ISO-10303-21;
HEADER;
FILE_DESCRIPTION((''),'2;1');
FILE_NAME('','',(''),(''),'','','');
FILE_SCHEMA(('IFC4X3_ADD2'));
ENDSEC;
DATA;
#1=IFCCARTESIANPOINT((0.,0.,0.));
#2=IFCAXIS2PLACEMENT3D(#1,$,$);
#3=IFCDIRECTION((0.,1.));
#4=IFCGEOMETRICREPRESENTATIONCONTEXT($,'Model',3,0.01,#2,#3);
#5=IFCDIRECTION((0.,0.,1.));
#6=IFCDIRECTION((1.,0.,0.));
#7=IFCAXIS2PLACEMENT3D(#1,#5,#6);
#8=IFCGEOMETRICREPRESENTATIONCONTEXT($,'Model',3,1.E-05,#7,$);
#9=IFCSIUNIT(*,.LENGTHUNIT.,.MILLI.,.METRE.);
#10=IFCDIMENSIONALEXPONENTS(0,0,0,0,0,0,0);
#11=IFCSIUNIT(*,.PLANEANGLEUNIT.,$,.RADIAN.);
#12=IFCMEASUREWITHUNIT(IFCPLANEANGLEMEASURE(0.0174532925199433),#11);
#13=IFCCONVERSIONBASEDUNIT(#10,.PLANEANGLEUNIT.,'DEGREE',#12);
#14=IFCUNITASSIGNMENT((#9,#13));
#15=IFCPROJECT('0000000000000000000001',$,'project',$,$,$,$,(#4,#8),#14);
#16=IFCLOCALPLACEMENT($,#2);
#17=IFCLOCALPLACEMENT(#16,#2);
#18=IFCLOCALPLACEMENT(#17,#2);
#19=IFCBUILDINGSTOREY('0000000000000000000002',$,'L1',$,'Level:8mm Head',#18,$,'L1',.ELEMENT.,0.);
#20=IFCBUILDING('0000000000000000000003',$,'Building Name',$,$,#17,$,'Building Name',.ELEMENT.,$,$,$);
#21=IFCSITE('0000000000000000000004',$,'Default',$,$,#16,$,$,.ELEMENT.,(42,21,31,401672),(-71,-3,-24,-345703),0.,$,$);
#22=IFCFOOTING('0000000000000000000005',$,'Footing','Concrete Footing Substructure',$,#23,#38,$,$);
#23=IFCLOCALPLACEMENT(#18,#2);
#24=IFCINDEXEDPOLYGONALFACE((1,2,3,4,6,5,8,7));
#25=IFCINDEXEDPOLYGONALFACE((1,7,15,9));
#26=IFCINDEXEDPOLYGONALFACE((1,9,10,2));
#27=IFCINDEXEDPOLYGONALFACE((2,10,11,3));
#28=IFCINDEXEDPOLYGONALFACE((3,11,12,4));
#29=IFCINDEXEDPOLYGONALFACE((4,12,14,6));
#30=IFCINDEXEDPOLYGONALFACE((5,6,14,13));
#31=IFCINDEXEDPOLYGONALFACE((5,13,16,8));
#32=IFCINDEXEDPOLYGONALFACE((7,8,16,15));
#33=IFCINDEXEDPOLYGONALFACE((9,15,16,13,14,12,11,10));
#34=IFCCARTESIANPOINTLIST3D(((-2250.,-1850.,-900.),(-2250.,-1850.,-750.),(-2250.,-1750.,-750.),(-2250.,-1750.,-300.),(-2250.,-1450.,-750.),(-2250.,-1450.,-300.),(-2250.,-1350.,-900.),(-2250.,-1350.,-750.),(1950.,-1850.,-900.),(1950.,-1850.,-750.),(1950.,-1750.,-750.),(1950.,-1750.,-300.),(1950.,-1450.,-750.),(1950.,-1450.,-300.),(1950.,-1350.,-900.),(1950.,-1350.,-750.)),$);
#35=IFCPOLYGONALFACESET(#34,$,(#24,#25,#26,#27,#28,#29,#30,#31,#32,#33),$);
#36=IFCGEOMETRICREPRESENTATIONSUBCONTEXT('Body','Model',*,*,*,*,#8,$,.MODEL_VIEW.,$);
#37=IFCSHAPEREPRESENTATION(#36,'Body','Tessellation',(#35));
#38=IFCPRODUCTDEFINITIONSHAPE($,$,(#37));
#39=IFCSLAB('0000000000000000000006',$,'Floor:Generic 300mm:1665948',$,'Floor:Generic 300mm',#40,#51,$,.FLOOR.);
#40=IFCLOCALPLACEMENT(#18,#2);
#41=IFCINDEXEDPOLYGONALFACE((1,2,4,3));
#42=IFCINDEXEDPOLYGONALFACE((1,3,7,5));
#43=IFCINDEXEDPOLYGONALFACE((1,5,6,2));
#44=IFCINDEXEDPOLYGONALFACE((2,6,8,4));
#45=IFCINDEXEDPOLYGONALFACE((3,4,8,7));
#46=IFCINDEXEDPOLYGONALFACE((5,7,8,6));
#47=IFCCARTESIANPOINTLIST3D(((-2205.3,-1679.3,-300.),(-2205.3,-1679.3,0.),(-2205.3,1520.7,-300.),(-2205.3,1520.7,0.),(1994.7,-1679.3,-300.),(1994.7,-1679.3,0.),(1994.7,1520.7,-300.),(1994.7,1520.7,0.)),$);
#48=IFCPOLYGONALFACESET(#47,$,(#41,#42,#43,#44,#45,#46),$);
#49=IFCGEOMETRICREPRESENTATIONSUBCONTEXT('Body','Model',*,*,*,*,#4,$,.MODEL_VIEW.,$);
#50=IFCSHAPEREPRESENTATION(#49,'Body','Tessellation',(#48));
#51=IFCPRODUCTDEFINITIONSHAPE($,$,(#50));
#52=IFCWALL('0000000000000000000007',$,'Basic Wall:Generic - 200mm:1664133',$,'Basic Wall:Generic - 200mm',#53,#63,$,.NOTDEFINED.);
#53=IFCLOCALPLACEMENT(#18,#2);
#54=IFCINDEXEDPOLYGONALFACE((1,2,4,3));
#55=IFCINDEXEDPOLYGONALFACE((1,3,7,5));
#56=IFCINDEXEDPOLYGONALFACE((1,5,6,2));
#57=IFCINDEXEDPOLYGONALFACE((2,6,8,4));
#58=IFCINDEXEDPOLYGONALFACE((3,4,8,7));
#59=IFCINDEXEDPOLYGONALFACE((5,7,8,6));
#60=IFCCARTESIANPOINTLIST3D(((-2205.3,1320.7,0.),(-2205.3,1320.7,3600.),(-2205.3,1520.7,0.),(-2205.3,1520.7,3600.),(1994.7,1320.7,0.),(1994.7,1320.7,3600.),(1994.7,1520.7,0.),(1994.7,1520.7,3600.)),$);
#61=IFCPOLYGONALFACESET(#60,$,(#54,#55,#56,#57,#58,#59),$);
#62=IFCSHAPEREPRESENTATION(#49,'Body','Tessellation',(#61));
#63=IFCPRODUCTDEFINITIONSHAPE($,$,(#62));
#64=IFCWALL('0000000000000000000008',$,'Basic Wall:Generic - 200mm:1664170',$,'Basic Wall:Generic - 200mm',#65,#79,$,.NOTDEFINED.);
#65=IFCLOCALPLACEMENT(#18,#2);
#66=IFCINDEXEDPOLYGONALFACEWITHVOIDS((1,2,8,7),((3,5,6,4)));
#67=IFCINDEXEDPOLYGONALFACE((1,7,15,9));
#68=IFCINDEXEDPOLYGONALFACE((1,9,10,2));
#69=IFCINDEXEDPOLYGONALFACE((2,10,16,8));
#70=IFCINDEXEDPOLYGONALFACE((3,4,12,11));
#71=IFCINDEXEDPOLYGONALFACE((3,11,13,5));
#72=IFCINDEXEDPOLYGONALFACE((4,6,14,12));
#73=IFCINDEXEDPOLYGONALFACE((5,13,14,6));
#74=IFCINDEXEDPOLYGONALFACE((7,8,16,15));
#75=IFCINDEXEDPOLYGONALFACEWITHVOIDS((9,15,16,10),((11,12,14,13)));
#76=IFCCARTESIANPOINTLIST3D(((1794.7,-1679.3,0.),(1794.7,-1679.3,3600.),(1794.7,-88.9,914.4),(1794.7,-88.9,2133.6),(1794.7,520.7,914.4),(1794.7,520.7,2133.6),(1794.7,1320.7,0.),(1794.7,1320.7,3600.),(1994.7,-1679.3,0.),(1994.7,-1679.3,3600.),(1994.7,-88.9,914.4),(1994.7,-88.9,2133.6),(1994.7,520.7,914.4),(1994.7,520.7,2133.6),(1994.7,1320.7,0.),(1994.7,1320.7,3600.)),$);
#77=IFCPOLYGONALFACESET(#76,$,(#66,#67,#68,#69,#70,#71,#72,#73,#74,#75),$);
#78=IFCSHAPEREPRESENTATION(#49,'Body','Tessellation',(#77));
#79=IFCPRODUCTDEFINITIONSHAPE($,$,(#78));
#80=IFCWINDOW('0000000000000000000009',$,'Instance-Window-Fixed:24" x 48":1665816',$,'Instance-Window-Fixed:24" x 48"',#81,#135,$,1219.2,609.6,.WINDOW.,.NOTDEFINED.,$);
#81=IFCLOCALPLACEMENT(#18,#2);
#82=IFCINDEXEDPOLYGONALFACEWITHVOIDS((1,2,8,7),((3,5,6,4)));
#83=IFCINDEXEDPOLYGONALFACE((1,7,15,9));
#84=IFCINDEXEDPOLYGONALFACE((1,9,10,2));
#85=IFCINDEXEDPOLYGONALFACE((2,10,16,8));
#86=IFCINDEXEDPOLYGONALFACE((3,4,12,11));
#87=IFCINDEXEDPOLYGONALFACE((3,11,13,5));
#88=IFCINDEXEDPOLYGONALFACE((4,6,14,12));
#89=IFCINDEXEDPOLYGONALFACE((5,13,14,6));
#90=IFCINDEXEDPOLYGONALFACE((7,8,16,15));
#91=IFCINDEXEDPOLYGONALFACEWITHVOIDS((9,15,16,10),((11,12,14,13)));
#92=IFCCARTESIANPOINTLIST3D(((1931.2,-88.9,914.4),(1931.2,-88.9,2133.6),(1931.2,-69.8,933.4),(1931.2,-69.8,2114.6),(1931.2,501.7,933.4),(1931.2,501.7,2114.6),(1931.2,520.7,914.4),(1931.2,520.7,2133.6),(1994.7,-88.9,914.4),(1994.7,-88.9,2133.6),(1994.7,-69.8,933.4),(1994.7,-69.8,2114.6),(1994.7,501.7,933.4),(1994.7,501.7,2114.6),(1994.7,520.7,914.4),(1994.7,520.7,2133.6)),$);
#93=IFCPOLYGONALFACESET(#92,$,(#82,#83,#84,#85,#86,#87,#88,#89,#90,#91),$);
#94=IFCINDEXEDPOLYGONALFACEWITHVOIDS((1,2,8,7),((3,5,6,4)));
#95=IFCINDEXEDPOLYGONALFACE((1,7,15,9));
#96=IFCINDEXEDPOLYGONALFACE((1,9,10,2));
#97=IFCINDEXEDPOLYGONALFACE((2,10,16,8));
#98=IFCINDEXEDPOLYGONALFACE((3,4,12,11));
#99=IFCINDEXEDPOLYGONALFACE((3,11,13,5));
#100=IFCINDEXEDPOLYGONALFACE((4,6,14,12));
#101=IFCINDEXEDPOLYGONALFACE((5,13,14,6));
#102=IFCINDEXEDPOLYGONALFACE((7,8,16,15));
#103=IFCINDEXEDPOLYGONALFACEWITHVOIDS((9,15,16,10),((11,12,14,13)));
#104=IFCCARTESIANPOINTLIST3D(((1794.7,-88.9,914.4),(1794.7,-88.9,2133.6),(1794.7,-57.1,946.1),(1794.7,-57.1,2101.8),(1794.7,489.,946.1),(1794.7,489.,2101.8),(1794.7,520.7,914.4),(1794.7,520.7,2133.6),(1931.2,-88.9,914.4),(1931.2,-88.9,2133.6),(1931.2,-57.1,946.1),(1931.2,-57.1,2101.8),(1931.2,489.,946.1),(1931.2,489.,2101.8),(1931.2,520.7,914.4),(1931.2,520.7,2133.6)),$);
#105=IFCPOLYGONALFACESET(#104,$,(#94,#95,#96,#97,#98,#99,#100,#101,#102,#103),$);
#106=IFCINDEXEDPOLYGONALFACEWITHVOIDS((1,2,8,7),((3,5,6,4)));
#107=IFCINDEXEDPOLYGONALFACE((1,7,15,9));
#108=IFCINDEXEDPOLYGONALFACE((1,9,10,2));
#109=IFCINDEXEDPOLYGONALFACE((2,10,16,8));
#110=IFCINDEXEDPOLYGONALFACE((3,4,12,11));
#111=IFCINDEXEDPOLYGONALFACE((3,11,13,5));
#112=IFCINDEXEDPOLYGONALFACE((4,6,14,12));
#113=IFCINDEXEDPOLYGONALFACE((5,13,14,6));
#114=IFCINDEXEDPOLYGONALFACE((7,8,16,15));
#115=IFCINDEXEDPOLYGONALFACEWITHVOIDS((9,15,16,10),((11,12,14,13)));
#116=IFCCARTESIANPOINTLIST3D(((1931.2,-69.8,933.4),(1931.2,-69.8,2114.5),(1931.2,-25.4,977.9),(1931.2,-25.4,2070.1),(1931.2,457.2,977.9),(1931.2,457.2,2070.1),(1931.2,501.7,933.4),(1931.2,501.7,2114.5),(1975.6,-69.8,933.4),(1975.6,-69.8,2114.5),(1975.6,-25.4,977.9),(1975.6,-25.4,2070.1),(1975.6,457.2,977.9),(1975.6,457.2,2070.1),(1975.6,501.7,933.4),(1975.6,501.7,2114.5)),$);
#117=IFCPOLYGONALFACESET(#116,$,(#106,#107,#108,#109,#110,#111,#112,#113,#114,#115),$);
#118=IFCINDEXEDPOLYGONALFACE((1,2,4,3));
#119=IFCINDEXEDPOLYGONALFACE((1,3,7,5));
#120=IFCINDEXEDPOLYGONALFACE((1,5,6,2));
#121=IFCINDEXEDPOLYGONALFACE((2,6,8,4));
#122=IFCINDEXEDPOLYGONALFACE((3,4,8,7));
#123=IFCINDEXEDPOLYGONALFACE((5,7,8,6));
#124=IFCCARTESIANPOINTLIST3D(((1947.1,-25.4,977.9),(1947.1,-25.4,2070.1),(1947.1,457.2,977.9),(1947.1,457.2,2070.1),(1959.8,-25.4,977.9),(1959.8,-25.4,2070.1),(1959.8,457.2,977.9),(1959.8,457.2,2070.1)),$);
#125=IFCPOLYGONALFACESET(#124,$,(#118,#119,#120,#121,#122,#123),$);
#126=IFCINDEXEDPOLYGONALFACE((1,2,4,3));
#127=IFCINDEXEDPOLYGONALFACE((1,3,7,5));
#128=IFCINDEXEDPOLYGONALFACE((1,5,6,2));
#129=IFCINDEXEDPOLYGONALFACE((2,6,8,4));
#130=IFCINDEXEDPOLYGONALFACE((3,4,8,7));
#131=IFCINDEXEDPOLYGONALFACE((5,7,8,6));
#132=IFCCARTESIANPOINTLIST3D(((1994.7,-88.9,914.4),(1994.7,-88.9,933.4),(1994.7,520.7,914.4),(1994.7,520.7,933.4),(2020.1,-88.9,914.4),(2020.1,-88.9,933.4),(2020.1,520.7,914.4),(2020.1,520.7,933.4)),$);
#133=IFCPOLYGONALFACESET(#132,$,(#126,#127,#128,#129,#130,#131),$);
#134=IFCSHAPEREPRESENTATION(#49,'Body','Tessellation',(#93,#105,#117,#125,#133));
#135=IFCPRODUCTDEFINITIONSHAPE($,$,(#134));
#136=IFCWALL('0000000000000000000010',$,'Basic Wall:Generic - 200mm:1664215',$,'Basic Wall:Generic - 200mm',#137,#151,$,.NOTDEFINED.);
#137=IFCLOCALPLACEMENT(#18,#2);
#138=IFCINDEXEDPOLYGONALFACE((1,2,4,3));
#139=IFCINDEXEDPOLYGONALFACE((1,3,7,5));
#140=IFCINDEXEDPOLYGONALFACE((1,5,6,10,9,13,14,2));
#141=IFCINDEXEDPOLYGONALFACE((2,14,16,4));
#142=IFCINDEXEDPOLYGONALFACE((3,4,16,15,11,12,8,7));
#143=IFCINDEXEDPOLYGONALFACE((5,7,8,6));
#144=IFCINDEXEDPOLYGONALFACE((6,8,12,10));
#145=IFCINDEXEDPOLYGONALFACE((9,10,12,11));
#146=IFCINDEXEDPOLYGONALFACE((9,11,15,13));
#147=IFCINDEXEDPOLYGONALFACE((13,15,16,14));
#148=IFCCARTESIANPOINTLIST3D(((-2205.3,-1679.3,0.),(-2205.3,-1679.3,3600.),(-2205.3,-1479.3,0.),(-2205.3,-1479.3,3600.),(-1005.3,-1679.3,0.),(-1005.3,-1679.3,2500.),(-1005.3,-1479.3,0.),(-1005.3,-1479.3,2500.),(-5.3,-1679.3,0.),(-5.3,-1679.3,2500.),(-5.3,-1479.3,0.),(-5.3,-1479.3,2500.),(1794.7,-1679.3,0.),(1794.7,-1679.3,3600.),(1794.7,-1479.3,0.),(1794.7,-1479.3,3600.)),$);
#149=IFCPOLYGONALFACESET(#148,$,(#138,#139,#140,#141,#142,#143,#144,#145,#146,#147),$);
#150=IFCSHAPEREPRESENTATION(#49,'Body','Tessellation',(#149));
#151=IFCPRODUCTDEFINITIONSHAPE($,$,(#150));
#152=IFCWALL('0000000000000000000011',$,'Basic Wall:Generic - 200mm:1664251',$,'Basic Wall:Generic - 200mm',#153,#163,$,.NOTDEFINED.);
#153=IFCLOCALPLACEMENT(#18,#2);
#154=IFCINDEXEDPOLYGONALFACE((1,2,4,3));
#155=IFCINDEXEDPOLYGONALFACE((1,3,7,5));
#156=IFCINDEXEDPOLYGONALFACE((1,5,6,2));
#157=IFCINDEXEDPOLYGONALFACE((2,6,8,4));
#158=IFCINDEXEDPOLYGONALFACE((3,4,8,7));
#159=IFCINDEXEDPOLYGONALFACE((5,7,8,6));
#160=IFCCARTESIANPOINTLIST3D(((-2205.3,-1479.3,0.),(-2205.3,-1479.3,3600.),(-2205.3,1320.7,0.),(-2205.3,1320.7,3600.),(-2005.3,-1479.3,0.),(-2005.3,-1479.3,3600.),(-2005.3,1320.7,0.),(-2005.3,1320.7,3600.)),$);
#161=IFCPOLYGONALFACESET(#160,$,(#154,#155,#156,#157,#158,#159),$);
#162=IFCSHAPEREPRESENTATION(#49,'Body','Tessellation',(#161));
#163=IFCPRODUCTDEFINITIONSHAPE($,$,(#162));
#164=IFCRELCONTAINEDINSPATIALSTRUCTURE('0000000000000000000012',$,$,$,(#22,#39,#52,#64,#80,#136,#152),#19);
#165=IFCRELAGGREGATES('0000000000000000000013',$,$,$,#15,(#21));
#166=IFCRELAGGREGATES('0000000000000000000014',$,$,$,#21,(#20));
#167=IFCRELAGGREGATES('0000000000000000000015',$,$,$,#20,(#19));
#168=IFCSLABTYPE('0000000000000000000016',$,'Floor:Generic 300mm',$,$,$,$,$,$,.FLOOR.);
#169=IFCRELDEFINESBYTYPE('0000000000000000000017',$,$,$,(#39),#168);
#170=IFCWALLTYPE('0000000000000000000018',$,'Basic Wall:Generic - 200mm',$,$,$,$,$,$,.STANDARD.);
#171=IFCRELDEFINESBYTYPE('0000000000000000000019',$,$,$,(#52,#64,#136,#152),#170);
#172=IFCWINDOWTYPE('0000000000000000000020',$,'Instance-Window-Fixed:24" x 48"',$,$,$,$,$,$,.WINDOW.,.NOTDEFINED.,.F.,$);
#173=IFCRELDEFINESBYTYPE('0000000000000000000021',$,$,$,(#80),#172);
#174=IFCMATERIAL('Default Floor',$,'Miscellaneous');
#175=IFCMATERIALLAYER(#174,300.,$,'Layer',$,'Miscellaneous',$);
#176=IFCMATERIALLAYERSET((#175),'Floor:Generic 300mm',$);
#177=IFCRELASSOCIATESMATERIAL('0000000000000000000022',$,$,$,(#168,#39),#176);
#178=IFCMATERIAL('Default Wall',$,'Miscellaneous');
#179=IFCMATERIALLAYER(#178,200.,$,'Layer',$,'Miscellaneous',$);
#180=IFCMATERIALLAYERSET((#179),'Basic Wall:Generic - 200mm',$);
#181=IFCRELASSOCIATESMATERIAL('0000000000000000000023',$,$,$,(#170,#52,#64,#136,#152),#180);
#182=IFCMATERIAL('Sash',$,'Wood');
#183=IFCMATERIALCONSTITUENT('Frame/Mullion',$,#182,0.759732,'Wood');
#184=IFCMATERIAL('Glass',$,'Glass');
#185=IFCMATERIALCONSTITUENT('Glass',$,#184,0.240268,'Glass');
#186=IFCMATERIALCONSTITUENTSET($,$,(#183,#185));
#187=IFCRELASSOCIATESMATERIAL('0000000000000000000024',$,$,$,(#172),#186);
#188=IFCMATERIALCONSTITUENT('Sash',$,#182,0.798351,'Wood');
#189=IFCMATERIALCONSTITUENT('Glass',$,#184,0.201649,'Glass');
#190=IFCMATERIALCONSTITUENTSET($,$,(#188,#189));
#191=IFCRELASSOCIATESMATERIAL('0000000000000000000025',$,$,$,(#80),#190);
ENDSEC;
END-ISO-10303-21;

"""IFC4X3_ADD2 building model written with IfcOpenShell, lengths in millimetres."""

from ifc_helpers import new_model, entity, si_unit, converted_unit, direction, frame, frame_2d, origin, origin_with_axes, origin_2d_with_axis, place, context, subcontext, project, spatial, polyline, rectangle, t_section, outline, extrude, source, transform, mapped, material, layer, layer_set, layer_usage, constituent, constituent_set, type_object, type_shapes, element, fill, save


model = new_model("IFC4X3_ADD2")

# Units and contexts
model_context_1 = context("Model", 3, precision=0.01, world=origin(), true_north=direction((0.0, 1.0)))
model_context_2 = context("Model", 3, precision=1e-05, world=origin_with_axes())
body_context_1 = subcontext(model_context_1, "Body", "Model", "MODEL_VIEW")
body_context_2 = subcontext(model_context_2, "Body", "Model", "MODEL_VIEW")
ifc_project = project(units=[si_unit("LENGTHUNIT", "METRE", prefix="MILLI"), converted_unit("PLANEANGLEUNIT", "DEGREE", entity("IfcPlaneAngleMeasure", 0.0174532925199433), si_unit("PLANEANGLEUNIT", "RADIAN"), dimensions=[0, 0, 0, 0, 0, 0, 0])], contexts=[model_context_1, model_context_2])

# Site, building, storey
site_placement = place(None, origin())
site = spatial("IfcSite", under=ifc_project, at=site_placement, Name="Default", CompositionType="ELEMENT", RefLatitude=(42, 21, 31, 401672), RefLongitude=(-71, -3, -24, -345703), RefElevation=0.0)
building_placement = place(site_placement, origin())
building = spatial("IfcBuilding", under=site, at=building_placement, Name="Building Name", LongName="Building Name", CompositionType="ELEMENT")
storey_placement = place(building_placement, origin())
storey = spatial("IfcBuildingStorey", under=building, at=storey_placement, Name="L1", ObjectType="Level:8mm Head", LongName="L1", CompositionType="ELEMENT", Elevation=0.0)

# Footing
footing_placement = place(storey_placement, frame((-2250.0, -1600.0, -600.0), z_axis=(1.0, 0.0, 0.0), x_axis=(0.0, -1.0, 0.0)))
element("IfcFooting", 1, at=footing_placement, inside=storey, Name="Footing", Description="Concrete Footing Substructure", context=body_context_2, shape_type="SweptSolid", body=[
    extrude(t_section(Depth=600.0, FlangeWidth=500.0, WebThickness=300.0, FlangeThickness=150.0), origin_with_axes(), (0.0, 0.0, 1.0), 4200.0),
])

# Slab
ifc_material_1 = material(Name="Default Floor", Category="Miscellaneous")
ifc_layer_1 = layer(ifc_material_1, 300.0, Name="Layer", Category="Miscellaneous")
ifc_layer_set_1 = layer_set([ifc_layer_1], Name="Floor:Generic 300mm")
ifc_layer_usage = layer_usage(ifc_layer_set_1, "AXIS3", "POSITIVE", 0.0)
slab_type = type_object("IfcSlabType", Name="Floor:Generic 300mm", PredefinedType="FLOOR", material=ifc_layer_set_1)
slab_placement = place(storey_placement, origin())
element("IfcSlab", 2, at=slab_placement, inside=storey, type_object=slab_type, material=ifc_layer_usage, Name="Floor:Generic 300mm:1665948", ObjectType="Floor:Generic 300mm", PredefinedType="FLOOR", context=body_context_1, shape_type="SweptSolid", body=[
    extrude(rectangle(XDim=3200.0, YDim=4200.0, at=origin_2d_with_axis()), frame((-105.3, -79.3, 0.0), z_axis=(0.0, 0.0, -1.0), x_axis=(0.0, 1.0, 0.0)), (0.0, 0.0, 1.0), 300.0),
])

# Wall
ifc_material_2 = material(Name="Default Wall", Category="Miscellaneous")
ifc_layer_2 = layer(ifc_material_2, 200.0, Name="Layer", Category="Miscellaneous")
ifc_layer_set_2 = layer_set([ifc_layer_2], Name="Basic Wall:Generic - 200mm")
wall_type = type_object("IfcWallType", Name="Basic Wall:Generic - 200mm", PredefinedType="STANDARD", material=ifc_layer_set_2)
wall_1_placement = place(storey_placement, frame((-2205.3, 1420.7, 0.0)))
element("IfcWall", 3, at=wall_1_placement, inside=storey, type_object=wall_type, material=ifc_layer_set_2, Name="Basic Wall:Generic - 200mm:1664133", ObjectType="Basic Wall:Generic - 200mm", PredefinedType="NOTDEFINED", context=body_context_1, shape_type="SweptSolid", body=[
    extrude(rectangle(XDim=4200.0, YDim=200.0, at=frame_2d((2100.0, 0.0), x_axis=(-1.0, 0.0))), origin(), (0.0, 0.0, 1.0), 3600.0),
])

# Wall, opening, window
wall_2_placement = place(storey_placement, frame((1894.7, 1320.7, 0.0), z_axis=(0.0, 0.0, 1.0), x_axis=(0.0, -1.0, 0.0)))
wall_2 = element("IfcWall", 4, at=wall_2_placement, inside=storey, type_object=wall_type, material=ifc_layer_set_2, Name="Basic Wall:Generic - 200mm:1664170", ObjectType="Basic Wall:Generic - 200mm", PredefinedType="NOTDEFINED", context=body_context_1, shape_type="SweptSolid", body=[
    extrude(rectangle(XDim=3000.0, YDim=200.0, at=frame_2d((1500.0, 0.0), x_axis=(-1.0, 0.0))), origin(), (0.0, 0.0, 1.0), 3600.0),
])
opening_1_placement = place(wall_2_placement, frame((800.0, -100.0, 914.4)))
opening_1 = element("IfcOpeningElement", 5, at=opening_1_placement, cuts=wall_2, PredefinedType="OPENING", context=body_context_1, shape_type="SweptSolid", body=[
    extrude(rectangle(XDim=1219.2, YDim=609.6, at=frame_2d((609.6, 304.8), x_axis=(-1.0, 0.0))), frame((0.0, 0.0, 0.0), z_axis=(0.0, 1.0, 0.0), x_axis=(0.0, 0.0, 1.0)), (0.0, 0.0, 1.0), 200.0),
])
ifc_material_3 = material(Name="Sash", Category="Wood")
ifc_constituent_1 = constituent(ifc_material_3, Name="Sash", Category="Wood", fraction=0.798351)
ifc_material_4 = material(Name="Glass", Category="Glass")
ifc_constituent_2 = constituent(ifc_material_4, Name="Glass", Category="Glass", fraction=0.201649)
ifc_constituent_set_1 = constituent_set(constituents=[ifc_constituent_1, ifc_constituent_2])
ifc_constituent_3 = constituent(ifc_material_3, Name="Frame/Mullion", Category="Wood", fraction=0.759732)
ifc_constituent_4 = constituent(ifc_material_4, Name="Glass", Category="Glass", fraction=0.240268)
ifc_constituent_set_2 = constituent_set(constituents=[ifc_constituent_3, ifc_constituent_4])
window_type = type_object("IfcWindowType", Name="Instance-Window-Fixed:24\" x 48\"", ParameterTakesPrecedence=False, PartitioningType="NOTDEFINED", PredefinedType="WINDOW", material=ifc_constituent_set_2)
shared_shape = source(origin(), body_context_1, "Body", "SweptSolid", [
    extrude(outline(polyline([(-609.6, -304.8), (609.6, -304.8), (609.6, 304.8), (-609.6, 304.8), (-609.6, -304.8)]), holes=[polyline([(-590.5, -285.7), (-590.5, 285.8), (590.6, 285.8), (590.6, -285.7), (-590.5, -285.7)])]), frame((304.8, 136.5, 609.6), z_axis=(0.0, 1.0, 0.0), x_axis=(0.0, 0.0, -1.0)), (0.0, 0.0, 1.0), 63.5),
    extrude(outline(polyline([(-304.8, -609.6), (304.8, -609.6), (304.8, 609.6), (-304.8, 609.6), (-304.8, -609.6)]), holes=[polyline([(-273.1, -577.8), (-273.1, 577.9), (273.0, 577.9), (273.0, -577.8), (-273.1, -577.8)])]), frame((304.8, 0.0, 609.6), z_axis=(0.0, 1.0, 0.0), x_axis=(1.0, 0.0, 0.0)), (0.0, 0.0, 1.0), 136.5),
    extrude(outline(polyline([(-285.8, -590.6), (285.8, -590.6), (285.8, 590.6), (-285.8, 590.6), (-285.8, -590.6)]), holes=[polyline([(-241.3, -546.1), (-241.3, 546.1), (241.3, 546.1), (241.3, -546.1), (-241.3, -546.1)])]), frame((304.8, 136.5, 609.6), z_axis=(0.0, 1.0, 0.0), x_axis=(1.0, 0.0, 0.0)), (0.0, 0.0, 1.0), 44.5),
    extrude(rectangle(XDim=12.7, YDim=482.6, at=frame_2d((0.0, 0.0), x_axis=(1.0, 0.0))), frame((304.8, 158.7, 63.5), z_axis=(0.0, 0.0, 1.0), x_axis=(0.0, 1.0, 0.0)), (0.0, 0.0, 1.0), 1092.2),
    extrude(rectangle(XDim=25.4, YDim=609.6, at=frame_2d((0.0, 0.0), x_axis=(1.0, 0.0))), frame((304.8, 212.7, 0.0), z_axis=(0.0, 0.0, 1.0), x_axis=(0.0, -1.0, 0.0)), (0.0, 0.0, 1.0), 19.0),
])
type_shapes(window_type, [shared_shape])
window_placement = place(opening_1_placement, origin())
window = element("IfcWindow", 6, at=window_placement, inside=storey, type_object=window_type, material=ifc_constituent_set_1, Name="Instance-Window-Fixed:24\" x 48\":1665816", ObjectType="Instance-Window-Fixed:24\" x 48\"", OverallHeight=1219.2, OverallWidth=609.6, PartitioningType="NOTDEFINED", PredefinedType="WINDOW", context=body_context_1, shape_type="MappedRepresentation", body=[
    mapped(shared_shape, transform((0.0, 0.0, 0.0), scale=1.0)),
])
fill(opening_1, window)

# Wall, opening
wall_3_placement = place(storey_placement, frame((1794.7, -1579.3, 0.0), z_axis=(0.0, 0.0, 1.0), x_axis=(-1.0, 0.0, 0.0)))
wall_3 = element("IfcWall", 7, at=wall_3_placement, inside=storey, type_object=wall_type, material=ifc_layer_set_2, Name="Basic Wall:Generic - 200mm:1664215", ObjectType="Basic Wall:Generic - 200mm", PredefinedType="NOTDEFINED", context=body_context_1, shape_type="SweptSolid", body=[
    extrude(rectangle(XDim=4000.0, YDim=200.0, at=frame_2d((2000.0, 0.0), x_axis=(1.0, 0.0))), origin(), (0.0, 0.0, 1.0), 3600.0),
])
opening_2_placement = place(wall_3_placement, frame((1800.0, -100.0, 0.0)))
element("IfcOpeningElement", 8, at=opening_2_placement, cuts=wall_3, PredefinedType="OPENING", context=body_context_1, shape_type="SweptSolid", body=[
    extrude(rectangle(XDim=2500.0, YDim=1000.0, at=frame_2d((1250.0, 500.0), x_axis=(1.0, 0.0))), frame((0.0, 0.0, 0.0), z_axis=(0.0, 1.0, 0.0), x_axis=(0.0, 0.0, 1.0)), (0.0, 0.0, 1.0), 200.0),
])

# Wall
wall_4_placement = place(storey_placement, frame((-2105.3, -1479.3, 0.0), z_axis=(0.0, 0.0, 1.0), x_axis=(0.0, 1.0, 0.0)))
element("IfcWall", 9, at=wall_4_placement, inside=storey, type_object=wall_type, material=ifc_layer_set_2, Name="Basic Wall:Generic - 200mm:1664251", ObjectType="Basic Wall:Generic - 200mm", PredefinedType="NOTDEFINED", context=body_context_1, shape_type="SweptSolid", body=[
    extrude(rectangle(XDim=2800.0, YDim=200.0, at=frame_2d((1400.0, 0.0), x_axis=(-1.0, 0.0))), origin(), (0.0, 0.0, 1.0), 3600.0),
])

save(model, "model.ifc")
